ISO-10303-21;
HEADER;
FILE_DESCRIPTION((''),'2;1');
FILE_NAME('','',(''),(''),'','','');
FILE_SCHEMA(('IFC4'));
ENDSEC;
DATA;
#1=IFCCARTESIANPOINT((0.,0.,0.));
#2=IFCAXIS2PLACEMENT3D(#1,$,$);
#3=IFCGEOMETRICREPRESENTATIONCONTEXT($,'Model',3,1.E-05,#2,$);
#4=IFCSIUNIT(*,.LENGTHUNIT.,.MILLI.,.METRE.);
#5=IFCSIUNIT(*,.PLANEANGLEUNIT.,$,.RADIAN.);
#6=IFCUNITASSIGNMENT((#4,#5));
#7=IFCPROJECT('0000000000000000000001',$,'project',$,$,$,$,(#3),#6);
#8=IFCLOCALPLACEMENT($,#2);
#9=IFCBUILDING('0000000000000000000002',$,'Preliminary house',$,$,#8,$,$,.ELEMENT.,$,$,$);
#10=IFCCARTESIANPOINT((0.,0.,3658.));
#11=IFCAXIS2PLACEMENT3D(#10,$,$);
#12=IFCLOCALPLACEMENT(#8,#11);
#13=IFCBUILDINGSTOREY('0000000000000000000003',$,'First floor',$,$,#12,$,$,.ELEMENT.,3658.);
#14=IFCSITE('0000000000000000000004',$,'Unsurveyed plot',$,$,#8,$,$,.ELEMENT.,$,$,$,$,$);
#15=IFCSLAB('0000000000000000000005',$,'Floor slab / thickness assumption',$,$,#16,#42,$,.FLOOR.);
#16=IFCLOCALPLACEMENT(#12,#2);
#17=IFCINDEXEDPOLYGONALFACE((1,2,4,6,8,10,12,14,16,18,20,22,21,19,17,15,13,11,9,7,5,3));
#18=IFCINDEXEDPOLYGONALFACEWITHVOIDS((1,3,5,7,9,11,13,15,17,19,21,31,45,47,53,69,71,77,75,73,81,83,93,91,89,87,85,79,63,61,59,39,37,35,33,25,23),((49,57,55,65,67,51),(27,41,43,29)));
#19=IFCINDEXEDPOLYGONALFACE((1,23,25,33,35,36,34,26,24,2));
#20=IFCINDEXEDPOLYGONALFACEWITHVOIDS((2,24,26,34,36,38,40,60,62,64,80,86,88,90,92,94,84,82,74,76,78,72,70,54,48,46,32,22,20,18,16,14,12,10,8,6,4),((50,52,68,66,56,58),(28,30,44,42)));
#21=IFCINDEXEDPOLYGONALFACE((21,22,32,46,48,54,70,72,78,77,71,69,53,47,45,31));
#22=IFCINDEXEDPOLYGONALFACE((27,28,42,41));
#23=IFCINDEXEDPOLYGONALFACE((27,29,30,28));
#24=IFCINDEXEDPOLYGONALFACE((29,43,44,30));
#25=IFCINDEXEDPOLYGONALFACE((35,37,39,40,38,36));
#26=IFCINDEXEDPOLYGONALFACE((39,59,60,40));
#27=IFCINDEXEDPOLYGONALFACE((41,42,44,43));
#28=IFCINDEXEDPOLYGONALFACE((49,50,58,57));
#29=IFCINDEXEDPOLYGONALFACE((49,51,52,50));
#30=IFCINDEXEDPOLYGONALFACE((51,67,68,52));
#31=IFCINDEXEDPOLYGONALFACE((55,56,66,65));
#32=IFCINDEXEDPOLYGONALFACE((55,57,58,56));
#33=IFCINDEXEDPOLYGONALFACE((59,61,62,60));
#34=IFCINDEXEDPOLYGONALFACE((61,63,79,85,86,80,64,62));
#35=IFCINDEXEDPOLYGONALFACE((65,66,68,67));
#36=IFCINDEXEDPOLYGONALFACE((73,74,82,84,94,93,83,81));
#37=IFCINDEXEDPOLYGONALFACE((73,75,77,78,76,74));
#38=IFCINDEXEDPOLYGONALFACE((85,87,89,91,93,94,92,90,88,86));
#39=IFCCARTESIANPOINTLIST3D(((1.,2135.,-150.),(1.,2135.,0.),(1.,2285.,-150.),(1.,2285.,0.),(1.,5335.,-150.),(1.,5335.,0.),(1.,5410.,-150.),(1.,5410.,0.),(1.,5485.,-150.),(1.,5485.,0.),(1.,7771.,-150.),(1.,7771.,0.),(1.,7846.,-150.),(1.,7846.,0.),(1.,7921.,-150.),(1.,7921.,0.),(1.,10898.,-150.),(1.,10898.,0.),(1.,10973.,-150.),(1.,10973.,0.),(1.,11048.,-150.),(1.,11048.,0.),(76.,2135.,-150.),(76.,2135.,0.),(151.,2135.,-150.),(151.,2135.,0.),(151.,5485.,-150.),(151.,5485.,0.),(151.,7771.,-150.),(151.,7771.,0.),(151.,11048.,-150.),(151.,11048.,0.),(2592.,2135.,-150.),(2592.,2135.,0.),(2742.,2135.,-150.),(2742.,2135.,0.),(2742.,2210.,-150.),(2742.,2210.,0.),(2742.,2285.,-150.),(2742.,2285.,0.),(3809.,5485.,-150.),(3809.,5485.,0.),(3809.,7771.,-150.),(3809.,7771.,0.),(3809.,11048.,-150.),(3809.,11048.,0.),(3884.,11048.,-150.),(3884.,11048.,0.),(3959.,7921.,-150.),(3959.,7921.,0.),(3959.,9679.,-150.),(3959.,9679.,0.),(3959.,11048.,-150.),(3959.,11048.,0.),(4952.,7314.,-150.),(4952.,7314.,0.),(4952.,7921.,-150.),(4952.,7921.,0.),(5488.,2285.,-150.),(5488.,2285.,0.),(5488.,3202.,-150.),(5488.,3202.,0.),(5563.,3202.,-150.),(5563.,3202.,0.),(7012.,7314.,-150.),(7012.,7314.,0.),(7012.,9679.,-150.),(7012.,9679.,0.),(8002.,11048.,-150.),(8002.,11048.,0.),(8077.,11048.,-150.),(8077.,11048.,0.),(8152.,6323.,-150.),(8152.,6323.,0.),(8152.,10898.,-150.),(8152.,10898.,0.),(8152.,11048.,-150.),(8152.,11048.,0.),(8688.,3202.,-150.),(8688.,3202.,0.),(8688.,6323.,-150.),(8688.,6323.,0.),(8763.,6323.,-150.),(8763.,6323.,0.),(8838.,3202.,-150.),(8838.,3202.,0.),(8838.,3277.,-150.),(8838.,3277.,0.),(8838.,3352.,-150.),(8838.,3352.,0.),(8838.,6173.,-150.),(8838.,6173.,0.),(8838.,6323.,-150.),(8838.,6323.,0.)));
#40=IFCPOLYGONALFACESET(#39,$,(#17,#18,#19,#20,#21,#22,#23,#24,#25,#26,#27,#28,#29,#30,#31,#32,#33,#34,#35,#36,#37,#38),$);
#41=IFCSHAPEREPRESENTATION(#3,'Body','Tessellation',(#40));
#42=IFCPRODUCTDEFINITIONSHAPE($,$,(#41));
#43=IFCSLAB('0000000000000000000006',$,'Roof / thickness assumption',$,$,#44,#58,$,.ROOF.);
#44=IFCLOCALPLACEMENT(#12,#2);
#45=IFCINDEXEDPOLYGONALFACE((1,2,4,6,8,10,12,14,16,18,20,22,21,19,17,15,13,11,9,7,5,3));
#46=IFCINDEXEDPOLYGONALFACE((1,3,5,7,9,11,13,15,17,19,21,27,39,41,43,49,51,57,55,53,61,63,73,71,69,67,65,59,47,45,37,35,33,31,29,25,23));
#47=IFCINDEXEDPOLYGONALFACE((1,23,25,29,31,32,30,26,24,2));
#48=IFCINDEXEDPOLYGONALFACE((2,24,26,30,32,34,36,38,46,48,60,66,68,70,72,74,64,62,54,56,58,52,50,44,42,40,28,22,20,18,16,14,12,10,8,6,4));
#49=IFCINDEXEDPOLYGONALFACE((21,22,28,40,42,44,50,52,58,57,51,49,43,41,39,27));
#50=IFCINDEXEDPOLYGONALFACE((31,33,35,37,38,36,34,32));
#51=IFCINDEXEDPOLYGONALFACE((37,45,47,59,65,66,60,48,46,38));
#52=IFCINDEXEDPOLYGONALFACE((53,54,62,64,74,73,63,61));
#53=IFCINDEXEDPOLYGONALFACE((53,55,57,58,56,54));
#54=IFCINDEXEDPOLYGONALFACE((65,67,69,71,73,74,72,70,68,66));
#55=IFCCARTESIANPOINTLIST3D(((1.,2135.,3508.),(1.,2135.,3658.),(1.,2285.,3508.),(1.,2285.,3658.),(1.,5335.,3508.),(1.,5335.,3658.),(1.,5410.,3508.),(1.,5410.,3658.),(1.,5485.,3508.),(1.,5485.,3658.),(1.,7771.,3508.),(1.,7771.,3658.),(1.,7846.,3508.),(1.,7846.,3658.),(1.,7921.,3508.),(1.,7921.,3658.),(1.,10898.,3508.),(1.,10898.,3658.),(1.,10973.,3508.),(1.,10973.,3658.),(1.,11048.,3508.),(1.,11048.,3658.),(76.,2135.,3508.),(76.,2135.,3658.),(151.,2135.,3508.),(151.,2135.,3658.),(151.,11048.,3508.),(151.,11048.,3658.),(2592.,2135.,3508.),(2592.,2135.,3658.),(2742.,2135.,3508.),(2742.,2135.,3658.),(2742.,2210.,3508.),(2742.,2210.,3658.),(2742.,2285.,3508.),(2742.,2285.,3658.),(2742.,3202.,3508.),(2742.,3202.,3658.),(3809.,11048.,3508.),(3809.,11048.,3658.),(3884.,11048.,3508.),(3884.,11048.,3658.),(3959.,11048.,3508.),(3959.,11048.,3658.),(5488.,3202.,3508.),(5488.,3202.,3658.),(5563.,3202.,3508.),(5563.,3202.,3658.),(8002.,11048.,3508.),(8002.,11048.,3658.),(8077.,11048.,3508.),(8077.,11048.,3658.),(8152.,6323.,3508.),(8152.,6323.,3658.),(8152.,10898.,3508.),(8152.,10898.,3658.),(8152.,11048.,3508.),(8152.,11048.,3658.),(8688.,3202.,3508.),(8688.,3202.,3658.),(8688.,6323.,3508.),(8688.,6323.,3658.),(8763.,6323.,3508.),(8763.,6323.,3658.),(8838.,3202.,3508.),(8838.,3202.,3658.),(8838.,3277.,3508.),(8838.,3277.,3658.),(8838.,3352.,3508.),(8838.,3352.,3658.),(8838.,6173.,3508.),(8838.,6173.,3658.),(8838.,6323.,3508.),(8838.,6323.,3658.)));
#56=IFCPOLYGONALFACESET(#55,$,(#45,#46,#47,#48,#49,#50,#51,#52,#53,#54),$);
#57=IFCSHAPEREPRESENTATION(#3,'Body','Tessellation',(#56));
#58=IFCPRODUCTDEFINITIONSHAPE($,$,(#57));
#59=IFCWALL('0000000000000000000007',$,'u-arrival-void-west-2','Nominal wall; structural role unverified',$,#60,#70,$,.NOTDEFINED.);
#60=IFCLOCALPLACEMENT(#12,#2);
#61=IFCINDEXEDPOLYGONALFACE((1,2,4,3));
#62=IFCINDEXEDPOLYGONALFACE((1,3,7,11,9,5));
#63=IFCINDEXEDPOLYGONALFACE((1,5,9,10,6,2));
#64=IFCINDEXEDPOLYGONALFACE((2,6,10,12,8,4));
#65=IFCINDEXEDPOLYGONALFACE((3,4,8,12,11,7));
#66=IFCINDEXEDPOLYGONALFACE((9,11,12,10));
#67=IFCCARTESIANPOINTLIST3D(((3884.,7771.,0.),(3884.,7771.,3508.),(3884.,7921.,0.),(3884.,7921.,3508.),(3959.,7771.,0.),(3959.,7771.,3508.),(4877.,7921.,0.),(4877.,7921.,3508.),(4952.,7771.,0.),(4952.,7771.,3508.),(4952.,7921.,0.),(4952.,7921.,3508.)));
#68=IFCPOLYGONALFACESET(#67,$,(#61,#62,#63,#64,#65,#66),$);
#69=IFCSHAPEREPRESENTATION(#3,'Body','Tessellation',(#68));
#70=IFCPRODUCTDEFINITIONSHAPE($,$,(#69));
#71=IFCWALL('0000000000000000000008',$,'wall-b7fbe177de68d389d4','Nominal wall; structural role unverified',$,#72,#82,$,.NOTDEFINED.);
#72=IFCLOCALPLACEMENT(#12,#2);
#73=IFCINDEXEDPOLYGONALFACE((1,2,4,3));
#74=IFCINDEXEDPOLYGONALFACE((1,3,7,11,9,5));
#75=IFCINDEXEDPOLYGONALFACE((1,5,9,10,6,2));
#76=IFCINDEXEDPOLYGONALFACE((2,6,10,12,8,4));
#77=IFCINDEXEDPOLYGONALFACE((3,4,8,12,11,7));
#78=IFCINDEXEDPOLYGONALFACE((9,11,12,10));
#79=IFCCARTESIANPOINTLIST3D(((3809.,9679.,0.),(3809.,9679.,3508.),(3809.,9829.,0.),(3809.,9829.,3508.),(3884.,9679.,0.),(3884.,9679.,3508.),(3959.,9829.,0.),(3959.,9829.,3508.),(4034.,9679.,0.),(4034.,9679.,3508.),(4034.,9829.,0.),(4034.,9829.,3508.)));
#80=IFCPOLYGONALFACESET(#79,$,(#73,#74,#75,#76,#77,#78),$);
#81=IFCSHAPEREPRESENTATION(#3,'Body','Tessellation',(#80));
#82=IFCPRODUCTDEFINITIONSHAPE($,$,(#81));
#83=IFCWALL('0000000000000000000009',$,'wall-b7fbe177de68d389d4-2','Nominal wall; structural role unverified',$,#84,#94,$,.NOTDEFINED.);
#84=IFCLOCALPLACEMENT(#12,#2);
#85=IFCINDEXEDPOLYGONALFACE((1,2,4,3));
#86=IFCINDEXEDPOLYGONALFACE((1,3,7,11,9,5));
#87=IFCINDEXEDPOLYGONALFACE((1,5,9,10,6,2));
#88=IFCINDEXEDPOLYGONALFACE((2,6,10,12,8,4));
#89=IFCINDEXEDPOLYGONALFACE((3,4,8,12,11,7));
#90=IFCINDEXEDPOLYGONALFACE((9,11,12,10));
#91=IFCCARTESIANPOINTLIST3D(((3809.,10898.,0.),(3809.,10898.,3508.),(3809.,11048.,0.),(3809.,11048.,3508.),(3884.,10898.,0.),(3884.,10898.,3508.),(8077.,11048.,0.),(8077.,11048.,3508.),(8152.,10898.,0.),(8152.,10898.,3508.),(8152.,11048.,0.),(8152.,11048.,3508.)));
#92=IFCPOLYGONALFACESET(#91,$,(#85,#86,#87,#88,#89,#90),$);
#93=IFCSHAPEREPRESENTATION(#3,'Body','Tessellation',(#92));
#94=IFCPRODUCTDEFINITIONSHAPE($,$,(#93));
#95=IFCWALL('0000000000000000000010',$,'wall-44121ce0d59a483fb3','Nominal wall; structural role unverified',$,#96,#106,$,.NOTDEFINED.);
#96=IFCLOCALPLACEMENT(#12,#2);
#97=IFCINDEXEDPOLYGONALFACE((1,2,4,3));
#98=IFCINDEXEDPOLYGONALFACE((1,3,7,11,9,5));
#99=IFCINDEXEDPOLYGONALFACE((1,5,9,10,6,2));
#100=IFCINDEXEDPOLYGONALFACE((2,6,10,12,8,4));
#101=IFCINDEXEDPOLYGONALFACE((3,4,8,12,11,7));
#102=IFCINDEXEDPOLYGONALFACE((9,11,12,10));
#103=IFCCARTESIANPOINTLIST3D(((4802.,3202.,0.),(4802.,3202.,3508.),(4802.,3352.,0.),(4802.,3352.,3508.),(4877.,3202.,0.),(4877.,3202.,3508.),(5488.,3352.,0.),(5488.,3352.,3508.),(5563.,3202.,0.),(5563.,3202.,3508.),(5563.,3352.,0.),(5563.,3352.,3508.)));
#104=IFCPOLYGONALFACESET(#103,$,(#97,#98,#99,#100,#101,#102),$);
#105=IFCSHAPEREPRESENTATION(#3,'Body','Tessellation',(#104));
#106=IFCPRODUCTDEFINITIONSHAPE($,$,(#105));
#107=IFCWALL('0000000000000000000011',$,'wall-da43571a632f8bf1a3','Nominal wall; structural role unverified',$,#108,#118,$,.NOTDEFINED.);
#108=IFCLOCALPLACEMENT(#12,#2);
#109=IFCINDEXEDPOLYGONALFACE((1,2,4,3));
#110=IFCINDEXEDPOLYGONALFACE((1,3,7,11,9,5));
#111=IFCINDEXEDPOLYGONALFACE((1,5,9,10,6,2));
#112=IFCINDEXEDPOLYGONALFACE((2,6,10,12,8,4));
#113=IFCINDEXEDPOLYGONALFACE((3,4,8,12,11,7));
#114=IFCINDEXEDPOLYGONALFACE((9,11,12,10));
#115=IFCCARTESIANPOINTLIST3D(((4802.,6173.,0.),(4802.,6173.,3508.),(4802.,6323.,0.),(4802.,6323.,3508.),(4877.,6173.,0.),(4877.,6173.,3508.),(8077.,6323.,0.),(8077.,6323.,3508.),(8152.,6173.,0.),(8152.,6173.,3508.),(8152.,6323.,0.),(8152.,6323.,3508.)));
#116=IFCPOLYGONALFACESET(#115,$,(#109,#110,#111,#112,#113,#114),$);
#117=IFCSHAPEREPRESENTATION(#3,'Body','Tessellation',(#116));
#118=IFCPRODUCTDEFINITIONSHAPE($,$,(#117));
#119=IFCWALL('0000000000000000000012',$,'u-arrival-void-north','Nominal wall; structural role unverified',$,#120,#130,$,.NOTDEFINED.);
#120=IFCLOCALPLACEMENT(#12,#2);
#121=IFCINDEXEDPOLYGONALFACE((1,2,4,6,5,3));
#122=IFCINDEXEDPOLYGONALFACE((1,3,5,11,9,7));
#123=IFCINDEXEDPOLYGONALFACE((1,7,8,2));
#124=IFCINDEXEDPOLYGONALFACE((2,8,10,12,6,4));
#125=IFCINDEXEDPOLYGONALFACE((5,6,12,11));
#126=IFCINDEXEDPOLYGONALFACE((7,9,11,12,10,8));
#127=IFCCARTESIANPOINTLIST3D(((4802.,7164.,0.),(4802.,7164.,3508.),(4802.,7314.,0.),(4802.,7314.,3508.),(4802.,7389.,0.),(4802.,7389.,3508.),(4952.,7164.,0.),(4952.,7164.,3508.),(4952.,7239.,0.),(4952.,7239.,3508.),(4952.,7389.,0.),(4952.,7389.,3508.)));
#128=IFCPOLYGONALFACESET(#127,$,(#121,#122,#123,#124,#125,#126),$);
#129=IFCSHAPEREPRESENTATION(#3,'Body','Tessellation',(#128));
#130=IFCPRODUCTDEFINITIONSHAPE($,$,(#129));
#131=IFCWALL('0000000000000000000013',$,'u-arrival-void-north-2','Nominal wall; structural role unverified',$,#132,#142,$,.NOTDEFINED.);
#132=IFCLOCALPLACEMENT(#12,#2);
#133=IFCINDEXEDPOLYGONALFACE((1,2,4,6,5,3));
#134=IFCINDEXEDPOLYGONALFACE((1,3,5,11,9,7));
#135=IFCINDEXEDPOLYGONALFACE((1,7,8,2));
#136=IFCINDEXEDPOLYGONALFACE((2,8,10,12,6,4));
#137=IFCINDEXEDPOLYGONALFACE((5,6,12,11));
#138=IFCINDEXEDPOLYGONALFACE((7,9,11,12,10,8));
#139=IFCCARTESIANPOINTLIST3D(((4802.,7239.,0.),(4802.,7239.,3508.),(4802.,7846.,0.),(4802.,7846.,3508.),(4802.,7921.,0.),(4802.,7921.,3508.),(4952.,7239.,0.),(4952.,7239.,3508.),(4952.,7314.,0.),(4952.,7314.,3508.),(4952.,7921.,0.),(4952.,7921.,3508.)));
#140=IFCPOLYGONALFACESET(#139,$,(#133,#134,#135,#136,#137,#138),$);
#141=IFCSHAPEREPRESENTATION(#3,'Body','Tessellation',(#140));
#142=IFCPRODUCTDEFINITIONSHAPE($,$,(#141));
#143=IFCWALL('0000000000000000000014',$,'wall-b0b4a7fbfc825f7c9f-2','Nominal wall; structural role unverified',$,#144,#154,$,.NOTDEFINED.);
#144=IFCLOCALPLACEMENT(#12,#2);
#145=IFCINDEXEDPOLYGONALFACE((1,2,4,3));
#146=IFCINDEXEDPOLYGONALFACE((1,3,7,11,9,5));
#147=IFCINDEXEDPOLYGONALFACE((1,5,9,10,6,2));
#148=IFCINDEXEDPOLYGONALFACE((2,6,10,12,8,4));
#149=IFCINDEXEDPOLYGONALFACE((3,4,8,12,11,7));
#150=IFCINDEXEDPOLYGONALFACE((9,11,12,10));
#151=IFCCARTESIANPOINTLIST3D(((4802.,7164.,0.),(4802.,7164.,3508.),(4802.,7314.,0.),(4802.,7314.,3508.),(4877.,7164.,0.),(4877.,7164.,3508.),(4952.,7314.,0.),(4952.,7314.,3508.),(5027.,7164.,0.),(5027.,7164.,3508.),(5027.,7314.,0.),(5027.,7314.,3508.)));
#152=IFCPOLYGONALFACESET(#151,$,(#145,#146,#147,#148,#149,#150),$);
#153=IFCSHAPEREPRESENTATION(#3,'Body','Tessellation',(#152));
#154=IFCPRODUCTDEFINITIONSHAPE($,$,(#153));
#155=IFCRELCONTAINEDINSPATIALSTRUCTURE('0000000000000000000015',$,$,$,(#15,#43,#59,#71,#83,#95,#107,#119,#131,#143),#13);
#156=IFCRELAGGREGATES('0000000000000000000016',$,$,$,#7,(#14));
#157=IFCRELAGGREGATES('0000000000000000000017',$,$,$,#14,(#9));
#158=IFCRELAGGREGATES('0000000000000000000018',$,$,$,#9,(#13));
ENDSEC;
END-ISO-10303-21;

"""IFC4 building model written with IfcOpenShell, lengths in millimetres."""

from ifc_helpers import new_model, si_unit, frame, origin, place, context, project, spatial, polyline, outline, extrude, element, save


model = new_model("IFC4")

# Units and contexts
model_context = context("Model", 3, precision=1e-05, world=origin())
ifc_project = project(units=[si_unit("LENGTHUNIT", "METRE", prefix="MILLI"), si_unit("PLANEANGLEUNIT", "RADIAN")], contexts=[model_context])

# Site, building, storey
placement_1 = place(None, origin())
site = spatial("IfcSite", under=ifc_project, at=placement_1, Name="Unsurveyed plot", CompositionType="ELEMENT")
building = spatial("IfcBuilding", under=site, at=placement_1, Name="Preliminary house", CompositionType="ELEMENT")
placement_2 = place(placement_1, frame((0.0, 0.0, 3658.0)))
storey = spatial("IfcBuildingStorey", under=building, at=placement_2, Name="First floor", CompositionType="ELEMENT", Elevation=3658.0)

# Slabs
element("IfcSlab", 1, at=placement_2, inside=storey, Name="Floor slab / thickness assumption", PredefinedType="FLOOR", context=model_context, shape_type="SweptSolid", body=[
    extrude(outline(polyline([(1.0, 2285.0), (1.0, 5335.0), (1.0, 5410.0), (1.0, 5485.0), (1.0, 7771.0), (1.0, 7846.0), (1.0, 7921.0), (1.0, 10898.0), (1.0, 10973.0), (1.0, 11048.0), (151.0, 11048.0), (3809.0, 11048.0), (3884.0, 11048.0), (3959.0, 11048.0), (8002.0, 11048.0), (8077.0, 11048.0), (8152.0, 11048.0), (8152.0, 10898.0), (8152.0, 6323.0), (8688.0, 6323.0), (8763.0, 6323.0), (8838.0, 6323.0), (8838.0, 6173.0), (8838.0, 3352.0), (8838.0, 3277.0), (8838.0, 3202.0), (8688.0, 3202.0), (5563.0, 3202.0), (5488.0, 3202.0), (5488.0, 2285.0), (2742.0, 2285.0), (2742.0, 2210.0), (2742.0, 2135.0), (2592.0, 2135.0), (151.0, 2135.0), (76.0, 2135.0), (1.0, 2135.0), (1.0, 2285.0)]), holes=[polyline([(7012.0, 9679.0), (3959.0, 9679.0), (3959.0, 7921.0), (4952.0, 7921.0), (4952.0, 7314.0), (7012.0, 7314.0), (7012.0, 9679.0)]), polyline([(151.0, 7771.0), (151.0, 5485.0), (3809.0, 5485.0), (3809.0, 7771.0), (151.0, 7771.0)])]), frame((0.0, 0.0, -150.0)), (0.0, 0.0, 1.0), 150.0),
])
element("IfcSlab", 2, at=placement_2, inside=storey, Name="Roof / thickness assumption", PredefinedType="ROOF", context=model_context, shape_type="SweptSolid", body=[
    extrude(outline(polyline([(1.0, 2135.0), (1.0, 2285.0), (1.0, 5335.0), (1.0, 5410.0), (1.0, 5485.0), (1.0, 7771.0), (1.0, 7846.0), (1.0, 7921.0), (1.0, 10898.0), (1.0, 10973.0), (1.0, 11048.0), (151.0, 11048.0), (3809.0, 11048.0), (3884.0, 11048.0), (3959.0, 11048.0), (8002.0, 11048.0), (8077.0, 11048.0), (8152.0, 11048.0), (8152.0, 10898.0), (8152.0, 6323.0), (8688.0, 6323.0), (8763.0, 6323.0), (8838.0, 6323.0), (8838.0, 6173.0), (8838.0, 3352.0), (8838.0, 3277.0), (8838.0, 3202.0), (8688.0, 3202.0), (5563.0, 3202.0), (5488.0, 3202.0), (2742.0, 3202.0), (2742.0, 2285.0), (2742.0, 2210.0), (2742.0, 2135.0), (2592.0, 2135.0), (151.0, 2135.0), (76.0, 2135.0), (1.0, 2135.0)])), frame((0.0, 0.0, 3508.0)), (0.0, 0.0, 1.0), 150.0),
])

# Wall
element("IfcWall", 3, at=placement_2, inside=storey, Name="u-arrival-void-west-2", Description="Nominal wall; structural role unverified", PredefinedType="NOTDEFINED", context=model_context, shape_type="SweptSolid", body=[
    extrude(outline(polyline([(4877.0, 7921.0), (4952.0, 7921.0), (4952.0, 7771.0), (3959.0, 7771.0), (3884.0, 7771.0), (3884.0, 7921.0), (4877.0, 7921.0)])), origin(), (0.0, 0.0, 1.0), 3508.0),
])

# Walls
element("IfcWall", 4, at=placement_2, inside=storey, Name="wall-b7fbe177de68d389d4", Description="Nominal wall; structural role unverified", PredefinedType="NOTDEFINED", context=model_context, shape_type="SweptSolid", body=[
    extrude(outline(polyline([(3959.0, 9829.0), (4034.0, 9829.0), (4034.0, 9679.0), (3884.0, 9679.0), (3809.0, 9679.0), (3809.0, 9829.0), (3959.0, 9829.0)])), origin(), (0.0, 0.0, 1.0), 3508.0),
])
element("IfcWall", 5, at=placement_2, inside=storey, Name="wall-b7fbe177de68d389d4-2", Description="Nominal wall; structural role unverified", PredefinedType="NOTDEFINED", context=model_context, shape_type="SweptSolid", body=[
    extrude(outline(polyline([(8077.0, 11048.0), (8152.0, 11048.0), (8152.0, 10898.0), (3884.0, 10898.0), (3809.0, 10898.0), (3809.0, 11048.0), (8077.0, 11048.0)])), origin(), (0.0, 0.0, 1.0), 3508.0),
])

# Wall
element("IfcWall", 6, at=placement_2, inside=storey, Name="wall-44121ce0d59a483fb3", Description="Nominal wall; structural role unverified", PredefinedType="NOTDEFINED", context=model_context, shape_type="SweptSolid", body=[
    extrude(outline(polyline([(5488.0, 3352.0), (5563.0, 3352.0), (5563.0, 3202.0), (4877.0, 3202.0), (4802.0, 3202.0), (4802.0, 3352.0), (5488.0, 3352.0)])), origin(), (0.0, 0.0, 1.0), 3508.0),
])

# Walls
element("IfcWall", 7, at=placement_2, inside=storey, Name="wall-da43571a632f8bf1a3", Description="Nominal wall; structural role unverified", PredefinedType="NOTDEFINED", context=model_context, shape_type="SweptSolid", body=[
    extrude(outline(polyline([(8077.0, 6323.0), (8152.0, 6323.0), (8152.0, 6173.0), (4877.0, 6173.0), (4802.0, 6173.0), (4802.0, 6323.0), (8077.0, 6323.0)])), origin(), (0.0, 0.0, 1.0), 3508.0),
])
element("IfcWall", 8, at=placement_2, inside=storey, Name="u-arrival-void-north", Description="Nominal wall; structural role unverified", PredefinedType="NOTDEFINED", context=model_context, shape_type="SweptSolid", body=[
    extrude(outline(polyline([(4802.0, 7314.0), (4802.0, 7389.0), (4952.0, 7389.0), (4952.0, 7239.0), (4952.0, 7164.0), (4802.0, 7164.0), (4802.0, 7314.0)])), origin(), (0.0, 0.0, 1.0), 3508.0),
])
element("IfcWall", 9, at=placement_2, inside=storey, Name="u-arrival-void-north-2", Description="Nominal wall; structural role unverified", PredefinedType="NOTDEFINED", context=model_context, shape_type="SweptSolid", body=[
    extrude(outline(polyline([(4802.0, 7846.0), (4802.0, 7921.0), (4952.0, 7921.0), (4952.0, 7314.0), (4952.0, 7239.0), (4802.0, 7239.0), (4802.0, 7846.0)])), origin(), (0.0, 0.0, 1.0), 3508.0),
])
element("IfcWall", 10, at=placement_2, inside=storey, Name="wall-b0b4a7fbfc825f7c9f-2", Description="Nominal wall; structural role unverified", PredefinedType="NOTDEFINED", context=model_context, shape_type="SweptSolid", body=[
    extrude(outline(polyline([(4952.0, 7314.0), (5027.0, 7314.0), (5027.0, 7164.0), (4877.0, 7164.0), (4802.0, 7164.0), (4802.0, 7314.0), (4952.0, 7314.0)])), origin(), (0.0, 0.0, 1.0), 3508.0),
])

save(model, "model.ifc")
